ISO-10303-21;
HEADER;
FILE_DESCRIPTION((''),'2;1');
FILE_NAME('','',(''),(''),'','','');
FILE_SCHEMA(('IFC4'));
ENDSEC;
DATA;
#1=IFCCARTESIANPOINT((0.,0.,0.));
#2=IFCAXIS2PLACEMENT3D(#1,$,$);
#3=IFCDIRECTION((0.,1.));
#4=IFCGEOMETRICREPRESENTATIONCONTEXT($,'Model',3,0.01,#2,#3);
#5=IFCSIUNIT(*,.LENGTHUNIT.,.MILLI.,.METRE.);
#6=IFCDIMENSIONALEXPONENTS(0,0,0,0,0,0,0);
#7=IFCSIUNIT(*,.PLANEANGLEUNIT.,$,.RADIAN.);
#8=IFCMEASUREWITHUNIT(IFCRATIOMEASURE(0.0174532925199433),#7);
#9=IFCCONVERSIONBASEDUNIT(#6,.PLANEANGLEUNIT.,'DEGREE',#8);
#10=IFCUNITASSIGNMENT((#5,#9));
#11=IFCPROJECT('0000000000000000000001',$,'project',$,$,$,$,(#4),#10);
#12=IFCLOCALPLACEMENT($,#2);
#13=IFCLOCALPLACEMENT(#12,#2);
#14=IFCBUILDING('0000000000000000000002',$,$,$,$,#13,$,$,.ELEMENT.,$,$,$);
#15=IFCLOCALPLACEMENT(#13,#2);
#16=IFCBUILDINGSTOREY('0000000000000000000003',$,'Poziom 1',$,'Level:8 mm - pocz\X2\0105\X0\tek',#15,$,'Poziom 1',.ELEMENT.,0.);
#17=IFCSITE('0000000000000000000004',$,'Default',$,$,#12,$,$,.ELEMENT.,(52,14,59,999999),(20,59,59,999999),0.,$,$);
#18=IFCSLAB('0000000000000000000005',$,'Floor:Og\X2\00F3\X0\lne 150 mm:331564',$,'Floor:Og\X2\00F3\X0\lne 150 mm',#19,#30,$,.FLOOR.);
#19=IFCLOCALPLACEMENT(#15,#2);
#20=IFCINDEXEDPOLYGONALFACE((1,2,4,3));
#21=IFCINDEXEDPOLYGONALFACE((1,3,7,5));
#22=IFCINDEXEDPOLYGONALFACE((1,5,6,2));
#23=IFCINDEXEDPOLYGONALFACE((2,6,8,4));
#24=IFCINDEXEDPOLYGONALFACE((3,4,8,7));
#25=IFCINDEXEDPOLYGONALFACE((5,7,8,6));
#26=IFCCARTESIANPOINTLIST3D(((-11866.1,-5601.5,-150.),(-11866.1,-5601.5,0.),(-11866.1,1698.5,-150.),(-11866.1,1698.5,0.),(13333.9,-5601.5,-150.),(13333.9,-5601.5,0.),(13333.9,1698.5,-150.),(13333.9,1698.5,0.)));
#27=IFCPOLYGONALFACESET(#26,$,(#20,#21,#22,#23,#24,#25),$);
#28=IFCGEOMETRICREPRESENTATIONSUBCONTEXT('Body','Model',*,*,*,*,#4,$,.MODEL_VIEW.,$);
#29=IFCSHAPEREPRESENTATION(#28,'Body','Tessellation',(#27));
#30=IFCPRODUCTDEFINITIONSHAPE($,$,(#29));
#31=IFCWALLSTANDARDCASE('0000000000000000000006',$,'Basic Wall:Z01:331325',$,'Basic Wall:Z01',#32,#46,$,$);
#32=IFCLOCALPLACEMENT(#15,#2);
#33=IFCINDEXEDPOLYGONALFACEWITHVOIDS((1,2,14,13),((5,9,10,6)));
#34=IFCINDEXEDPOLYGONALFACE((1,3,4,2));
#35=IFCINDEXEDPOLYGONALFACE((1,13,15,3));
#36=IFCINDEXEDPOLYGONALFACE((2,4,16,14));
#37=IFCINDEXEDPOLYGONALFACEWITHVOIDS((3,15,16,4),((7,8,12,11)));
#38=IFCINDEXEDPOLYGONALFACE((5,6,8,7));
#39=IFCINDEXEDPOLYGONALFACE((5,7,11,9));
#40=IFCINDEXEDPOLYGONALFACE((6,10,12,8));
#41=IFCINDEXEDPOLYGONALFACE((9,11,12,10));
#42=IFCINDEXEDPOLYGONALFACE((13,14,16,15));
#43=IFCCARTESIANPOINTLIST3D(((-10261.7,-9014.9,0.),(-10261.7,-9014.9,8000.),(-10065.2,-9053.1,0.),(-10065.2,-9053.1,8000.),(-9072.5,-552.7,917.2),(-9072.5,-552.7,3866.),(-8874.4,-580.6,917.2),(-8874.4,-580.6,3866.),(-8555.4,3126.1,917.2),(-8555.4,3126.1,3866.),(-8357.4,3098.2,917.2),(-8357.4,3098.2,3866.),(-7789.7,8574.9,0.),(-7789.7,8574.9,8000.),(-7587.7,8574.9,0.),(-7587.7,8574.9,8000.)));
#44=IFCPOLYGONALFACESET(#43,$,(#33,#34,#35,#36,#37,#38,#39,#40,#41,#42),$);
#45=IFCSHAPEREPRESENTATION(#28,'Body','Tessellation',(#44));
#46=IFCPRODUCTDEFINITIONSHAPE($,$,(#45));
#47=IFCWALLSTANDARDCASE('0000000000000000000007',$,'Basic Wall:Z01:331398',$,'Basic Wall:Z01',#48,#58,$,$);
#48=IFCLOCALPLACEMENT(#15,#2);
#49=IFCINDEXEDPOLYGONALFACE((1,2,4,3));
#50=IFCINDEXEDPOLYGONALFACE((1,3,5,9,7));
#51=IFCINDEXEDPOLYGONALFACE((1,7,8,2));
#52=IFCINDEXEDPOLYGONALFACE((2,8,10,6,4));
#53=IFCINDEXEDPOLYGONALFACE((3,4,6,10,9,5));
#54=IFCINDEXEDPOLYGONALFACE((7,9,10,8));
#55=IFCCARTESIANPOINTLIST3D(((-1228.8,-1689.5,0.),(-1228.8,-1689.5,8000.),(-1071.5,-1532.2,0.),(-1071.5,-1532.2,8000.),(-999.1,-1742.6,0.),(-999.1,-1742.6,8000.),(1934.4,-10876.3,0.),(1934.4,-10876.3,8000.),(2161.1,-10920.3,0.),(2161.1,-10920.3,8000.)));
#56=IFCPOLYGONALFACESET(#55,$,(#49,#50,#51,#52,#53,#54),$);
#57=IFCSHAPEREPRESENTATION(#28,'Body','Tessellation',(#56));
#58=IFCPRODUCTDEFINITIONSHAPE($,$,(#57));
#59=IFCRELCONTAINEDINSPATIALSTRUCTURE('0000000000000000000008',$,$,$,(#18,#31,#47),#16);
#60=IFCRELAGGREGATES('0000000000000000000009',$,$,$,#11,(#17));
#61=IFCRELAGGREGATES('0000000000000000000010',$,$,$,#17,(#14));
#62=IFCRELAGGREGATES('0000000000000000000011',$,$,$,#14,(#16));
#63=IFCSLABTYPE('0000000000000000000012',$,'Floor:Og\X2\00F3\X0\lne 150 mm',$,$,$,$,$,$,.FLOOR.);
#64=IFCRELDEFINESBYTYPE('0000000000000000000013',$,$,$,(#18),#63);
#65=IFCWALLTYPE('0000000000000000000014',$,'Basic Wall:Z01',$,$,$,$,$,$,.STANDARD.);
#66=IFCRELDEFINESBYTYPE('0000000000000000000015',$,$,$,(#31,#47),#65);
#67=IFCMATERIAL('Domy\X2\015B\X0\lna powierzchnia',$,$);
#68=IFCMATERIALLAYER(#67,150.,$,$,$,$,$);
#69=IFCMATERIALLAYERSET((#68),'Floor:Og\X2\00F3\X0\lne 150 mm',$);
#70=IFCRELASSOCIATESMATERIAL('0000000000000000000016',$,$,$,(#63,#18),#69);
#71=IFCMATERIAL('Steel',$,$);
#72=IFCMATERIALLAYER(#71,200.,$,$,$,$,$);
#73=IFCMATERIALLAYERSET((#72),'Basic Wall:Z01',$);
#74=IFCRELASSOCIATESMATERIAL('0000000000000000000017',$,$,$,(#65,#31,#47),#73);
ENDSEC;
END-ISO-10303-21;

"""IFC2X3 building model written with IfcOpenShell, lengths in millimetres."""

from ifc_helpers import new_model, entity, si_unit, converted_unit, direction, frame, frame_2d, origin, origin_2d_with_axis, place, context, subcontext, project, spatial, polyline, rectangle, outline, extrude, material, layer, layer_set, layer_usage, type_object, element, save


model = new_model("IFC2X3")

# Units and contexts
model_context = context("Model", 3, precision=0.01, world=origin(), true_north=direction((0.0, 1.0)))
body_context = subcontext(model_context, "Body", "Model", "MODEL_VIEW")
ifc_project = project(units=[si_unit("LENGTHUNIT", "METRE", prefix="MILLI"), converted_unit("PLANEANGLEUNIT", "DEGREE", entity("IfcRatioMeasure", 0.0174532925199433), si_unit("PLANEANGLEUNIT", "RADIAN"), dimensions=[0, 0, 0, 0, 0, 0, 0])], contexts=[model_context])

# Site, building, storey
site_placement = place(None, origin())
site = spatial("IfcSite", under=ifc_project, at=site_placement, Name="Default", CompositionType="ELEMENT", RefLatitude=(52, 14, 59, 999999), RefLongitude=(20, 59, 59, 999999), RefElevation=0.0)
building_placement = place(site_placement, origin())
building = spatial("IfcBuilding", under=site, at=building_placement, CompositionType="ELEMENT")
storey_placement = place(building_placement, origin())
storey = spatial("IfcBuildingStorey", under=building, at=storey_placement, Name="Poziom 1", ObjectType="Level:8 mm - początek", LongName="Poziom 1", CompositionType="ELEMENT", Elevation=0.0)

# Slab
ifc_material_1 = material(Name="Domyślna powierzchnia")
ifc_layer_1 = layer(ifc_material_1, 150.0)
ifc_layer_set_1 = layer_set([ifc_layer_1], Name="Floor:Ogólne 150 mm")
ifc_layer_usage_1 = layer_usage(ifc_layer_set_1, "AXIS3", "POSITIVE", 0.0)
slab_type = type_object("IfcSlabType", Name="Floor:Ogólne 150 mm", PredefinedType="FLOOR", material=ifc_layer_set_1)
slab_placement = place(storey_placement, origin())
element("IfcSlab", 1, at=slab_placement, inside=storey, type_object=slab_type, material=ifc_layer_usage_1, Name="Floor:Ogólne 150 mm:331564", ObjectType="Floor:Ogólne 150 mm", PredefinedType="FLOOR", context=body_context, shape_type="SweptSolid", body=[
    extrude(rectangle(XDim=7300.0, YDim=25200.0, at=frame_2d((0.0, 0.0), x_axis=(1.0, 0.0))), frame((733.9, -1951.5, 0.0), z_axis=(0.0, 0.0, -1.0), x_axis=(0.0, 1.0, 0.0)), (0.0, 0.0, 1.0), 150.0),
])

# Wall, opening
ifc_material_2 = material(Name="Steel")
ifc_layer_2 = layer(ifc_material_2, 200.0)
ifc_layer_set_2 = layer_set([ifc_layer_2], Name="Basic Wall:Z01")
ifc_layer_usage_2 = layer_usage(ifc_layer_set_2, "AXIS2", "NEGATIVE", 100.0)
wall_type_1 = type_object("IfcWallType", Name="Basic Wall:Z01", PredefinedType="STANDARD", material=ifc_layer_set_2)
wall_1_placement = place(storey_placement, frame((-7686.7, 8588.8, 0.0), z_axis=(0.0, 0.0, 1.0), x_axis=(-0.139173, -0.990268, 0.0)))
wall_1 = element("IfcWallStandardCase", 2, at=wall_1_placement, inside=storey, type_object=wall_type_1, material=ifc_layer_usage_2, Name="Basic Wall:Z01:331325", ObjectType="Basic Wall:Z01", context=body_context, shape_type="SweptSolid", body=[
    extrude(outline(polyline([(17790.8, -100.0), (17801.2, 100.0), (17300.6, 100.0), (504.9, 100.0), (0.0, 100.0), (28.1, -100.0), (17790.8, -100.0)])), origin(), (0.0, 0.0, 1.0), 8000.0),
])
opening_1_placement = place(wall_1_placement, origin())
element("IfcOpeningElement", 3, at=opening_1_placement, cuts=wall_1, ObjectType="Opening", context=body_context, shape_type="SweptSolid", body=[
    extrude(rectangle(XDim=2948.8, YDim=3715.0, at=origin_2d_with_axis()), frame((7387.9, -100.0, 2391.6), z_axis=(0.0, 1.0, 0.0), x_axis=(0.0, 0.0, -1.0)), (0.0, 0.0, 1.0), 200.0),
])

# Wall
ifc_layer_usage_3 = layer_usage(ifc_layer_set_2, "AXIS2", "NEGATIVE", 100.0)
wall_2_placement = place(storey_placement, frame((2066.5, -10952.9, 0.0), z_axis=(0.0, 0.0, 1.0), x_axis=(-0.325568, 0.945519, 0.0)))
element("IfcWallStandardCase", 4, at=wall_2_placement, inside=storey, type_object=wall_type_1, material=ifc_layer_usage_3, Name="Basic Wall:Z01:331398", ObjectType="Basic Wall:Z01", context=body_context, shape_type="SweptSolid", body=[
    extrude(outline(polyline([(9929.1, -100.0), (9831.5, 100.0), (115.5, 100.0), (0.0, -100.0), (9706.6, -100.0), (9929.1, -100.0)])), origin(), (0.0, 0.0, 1.0), 8000.0),
])

save(model, "model.ifc")
